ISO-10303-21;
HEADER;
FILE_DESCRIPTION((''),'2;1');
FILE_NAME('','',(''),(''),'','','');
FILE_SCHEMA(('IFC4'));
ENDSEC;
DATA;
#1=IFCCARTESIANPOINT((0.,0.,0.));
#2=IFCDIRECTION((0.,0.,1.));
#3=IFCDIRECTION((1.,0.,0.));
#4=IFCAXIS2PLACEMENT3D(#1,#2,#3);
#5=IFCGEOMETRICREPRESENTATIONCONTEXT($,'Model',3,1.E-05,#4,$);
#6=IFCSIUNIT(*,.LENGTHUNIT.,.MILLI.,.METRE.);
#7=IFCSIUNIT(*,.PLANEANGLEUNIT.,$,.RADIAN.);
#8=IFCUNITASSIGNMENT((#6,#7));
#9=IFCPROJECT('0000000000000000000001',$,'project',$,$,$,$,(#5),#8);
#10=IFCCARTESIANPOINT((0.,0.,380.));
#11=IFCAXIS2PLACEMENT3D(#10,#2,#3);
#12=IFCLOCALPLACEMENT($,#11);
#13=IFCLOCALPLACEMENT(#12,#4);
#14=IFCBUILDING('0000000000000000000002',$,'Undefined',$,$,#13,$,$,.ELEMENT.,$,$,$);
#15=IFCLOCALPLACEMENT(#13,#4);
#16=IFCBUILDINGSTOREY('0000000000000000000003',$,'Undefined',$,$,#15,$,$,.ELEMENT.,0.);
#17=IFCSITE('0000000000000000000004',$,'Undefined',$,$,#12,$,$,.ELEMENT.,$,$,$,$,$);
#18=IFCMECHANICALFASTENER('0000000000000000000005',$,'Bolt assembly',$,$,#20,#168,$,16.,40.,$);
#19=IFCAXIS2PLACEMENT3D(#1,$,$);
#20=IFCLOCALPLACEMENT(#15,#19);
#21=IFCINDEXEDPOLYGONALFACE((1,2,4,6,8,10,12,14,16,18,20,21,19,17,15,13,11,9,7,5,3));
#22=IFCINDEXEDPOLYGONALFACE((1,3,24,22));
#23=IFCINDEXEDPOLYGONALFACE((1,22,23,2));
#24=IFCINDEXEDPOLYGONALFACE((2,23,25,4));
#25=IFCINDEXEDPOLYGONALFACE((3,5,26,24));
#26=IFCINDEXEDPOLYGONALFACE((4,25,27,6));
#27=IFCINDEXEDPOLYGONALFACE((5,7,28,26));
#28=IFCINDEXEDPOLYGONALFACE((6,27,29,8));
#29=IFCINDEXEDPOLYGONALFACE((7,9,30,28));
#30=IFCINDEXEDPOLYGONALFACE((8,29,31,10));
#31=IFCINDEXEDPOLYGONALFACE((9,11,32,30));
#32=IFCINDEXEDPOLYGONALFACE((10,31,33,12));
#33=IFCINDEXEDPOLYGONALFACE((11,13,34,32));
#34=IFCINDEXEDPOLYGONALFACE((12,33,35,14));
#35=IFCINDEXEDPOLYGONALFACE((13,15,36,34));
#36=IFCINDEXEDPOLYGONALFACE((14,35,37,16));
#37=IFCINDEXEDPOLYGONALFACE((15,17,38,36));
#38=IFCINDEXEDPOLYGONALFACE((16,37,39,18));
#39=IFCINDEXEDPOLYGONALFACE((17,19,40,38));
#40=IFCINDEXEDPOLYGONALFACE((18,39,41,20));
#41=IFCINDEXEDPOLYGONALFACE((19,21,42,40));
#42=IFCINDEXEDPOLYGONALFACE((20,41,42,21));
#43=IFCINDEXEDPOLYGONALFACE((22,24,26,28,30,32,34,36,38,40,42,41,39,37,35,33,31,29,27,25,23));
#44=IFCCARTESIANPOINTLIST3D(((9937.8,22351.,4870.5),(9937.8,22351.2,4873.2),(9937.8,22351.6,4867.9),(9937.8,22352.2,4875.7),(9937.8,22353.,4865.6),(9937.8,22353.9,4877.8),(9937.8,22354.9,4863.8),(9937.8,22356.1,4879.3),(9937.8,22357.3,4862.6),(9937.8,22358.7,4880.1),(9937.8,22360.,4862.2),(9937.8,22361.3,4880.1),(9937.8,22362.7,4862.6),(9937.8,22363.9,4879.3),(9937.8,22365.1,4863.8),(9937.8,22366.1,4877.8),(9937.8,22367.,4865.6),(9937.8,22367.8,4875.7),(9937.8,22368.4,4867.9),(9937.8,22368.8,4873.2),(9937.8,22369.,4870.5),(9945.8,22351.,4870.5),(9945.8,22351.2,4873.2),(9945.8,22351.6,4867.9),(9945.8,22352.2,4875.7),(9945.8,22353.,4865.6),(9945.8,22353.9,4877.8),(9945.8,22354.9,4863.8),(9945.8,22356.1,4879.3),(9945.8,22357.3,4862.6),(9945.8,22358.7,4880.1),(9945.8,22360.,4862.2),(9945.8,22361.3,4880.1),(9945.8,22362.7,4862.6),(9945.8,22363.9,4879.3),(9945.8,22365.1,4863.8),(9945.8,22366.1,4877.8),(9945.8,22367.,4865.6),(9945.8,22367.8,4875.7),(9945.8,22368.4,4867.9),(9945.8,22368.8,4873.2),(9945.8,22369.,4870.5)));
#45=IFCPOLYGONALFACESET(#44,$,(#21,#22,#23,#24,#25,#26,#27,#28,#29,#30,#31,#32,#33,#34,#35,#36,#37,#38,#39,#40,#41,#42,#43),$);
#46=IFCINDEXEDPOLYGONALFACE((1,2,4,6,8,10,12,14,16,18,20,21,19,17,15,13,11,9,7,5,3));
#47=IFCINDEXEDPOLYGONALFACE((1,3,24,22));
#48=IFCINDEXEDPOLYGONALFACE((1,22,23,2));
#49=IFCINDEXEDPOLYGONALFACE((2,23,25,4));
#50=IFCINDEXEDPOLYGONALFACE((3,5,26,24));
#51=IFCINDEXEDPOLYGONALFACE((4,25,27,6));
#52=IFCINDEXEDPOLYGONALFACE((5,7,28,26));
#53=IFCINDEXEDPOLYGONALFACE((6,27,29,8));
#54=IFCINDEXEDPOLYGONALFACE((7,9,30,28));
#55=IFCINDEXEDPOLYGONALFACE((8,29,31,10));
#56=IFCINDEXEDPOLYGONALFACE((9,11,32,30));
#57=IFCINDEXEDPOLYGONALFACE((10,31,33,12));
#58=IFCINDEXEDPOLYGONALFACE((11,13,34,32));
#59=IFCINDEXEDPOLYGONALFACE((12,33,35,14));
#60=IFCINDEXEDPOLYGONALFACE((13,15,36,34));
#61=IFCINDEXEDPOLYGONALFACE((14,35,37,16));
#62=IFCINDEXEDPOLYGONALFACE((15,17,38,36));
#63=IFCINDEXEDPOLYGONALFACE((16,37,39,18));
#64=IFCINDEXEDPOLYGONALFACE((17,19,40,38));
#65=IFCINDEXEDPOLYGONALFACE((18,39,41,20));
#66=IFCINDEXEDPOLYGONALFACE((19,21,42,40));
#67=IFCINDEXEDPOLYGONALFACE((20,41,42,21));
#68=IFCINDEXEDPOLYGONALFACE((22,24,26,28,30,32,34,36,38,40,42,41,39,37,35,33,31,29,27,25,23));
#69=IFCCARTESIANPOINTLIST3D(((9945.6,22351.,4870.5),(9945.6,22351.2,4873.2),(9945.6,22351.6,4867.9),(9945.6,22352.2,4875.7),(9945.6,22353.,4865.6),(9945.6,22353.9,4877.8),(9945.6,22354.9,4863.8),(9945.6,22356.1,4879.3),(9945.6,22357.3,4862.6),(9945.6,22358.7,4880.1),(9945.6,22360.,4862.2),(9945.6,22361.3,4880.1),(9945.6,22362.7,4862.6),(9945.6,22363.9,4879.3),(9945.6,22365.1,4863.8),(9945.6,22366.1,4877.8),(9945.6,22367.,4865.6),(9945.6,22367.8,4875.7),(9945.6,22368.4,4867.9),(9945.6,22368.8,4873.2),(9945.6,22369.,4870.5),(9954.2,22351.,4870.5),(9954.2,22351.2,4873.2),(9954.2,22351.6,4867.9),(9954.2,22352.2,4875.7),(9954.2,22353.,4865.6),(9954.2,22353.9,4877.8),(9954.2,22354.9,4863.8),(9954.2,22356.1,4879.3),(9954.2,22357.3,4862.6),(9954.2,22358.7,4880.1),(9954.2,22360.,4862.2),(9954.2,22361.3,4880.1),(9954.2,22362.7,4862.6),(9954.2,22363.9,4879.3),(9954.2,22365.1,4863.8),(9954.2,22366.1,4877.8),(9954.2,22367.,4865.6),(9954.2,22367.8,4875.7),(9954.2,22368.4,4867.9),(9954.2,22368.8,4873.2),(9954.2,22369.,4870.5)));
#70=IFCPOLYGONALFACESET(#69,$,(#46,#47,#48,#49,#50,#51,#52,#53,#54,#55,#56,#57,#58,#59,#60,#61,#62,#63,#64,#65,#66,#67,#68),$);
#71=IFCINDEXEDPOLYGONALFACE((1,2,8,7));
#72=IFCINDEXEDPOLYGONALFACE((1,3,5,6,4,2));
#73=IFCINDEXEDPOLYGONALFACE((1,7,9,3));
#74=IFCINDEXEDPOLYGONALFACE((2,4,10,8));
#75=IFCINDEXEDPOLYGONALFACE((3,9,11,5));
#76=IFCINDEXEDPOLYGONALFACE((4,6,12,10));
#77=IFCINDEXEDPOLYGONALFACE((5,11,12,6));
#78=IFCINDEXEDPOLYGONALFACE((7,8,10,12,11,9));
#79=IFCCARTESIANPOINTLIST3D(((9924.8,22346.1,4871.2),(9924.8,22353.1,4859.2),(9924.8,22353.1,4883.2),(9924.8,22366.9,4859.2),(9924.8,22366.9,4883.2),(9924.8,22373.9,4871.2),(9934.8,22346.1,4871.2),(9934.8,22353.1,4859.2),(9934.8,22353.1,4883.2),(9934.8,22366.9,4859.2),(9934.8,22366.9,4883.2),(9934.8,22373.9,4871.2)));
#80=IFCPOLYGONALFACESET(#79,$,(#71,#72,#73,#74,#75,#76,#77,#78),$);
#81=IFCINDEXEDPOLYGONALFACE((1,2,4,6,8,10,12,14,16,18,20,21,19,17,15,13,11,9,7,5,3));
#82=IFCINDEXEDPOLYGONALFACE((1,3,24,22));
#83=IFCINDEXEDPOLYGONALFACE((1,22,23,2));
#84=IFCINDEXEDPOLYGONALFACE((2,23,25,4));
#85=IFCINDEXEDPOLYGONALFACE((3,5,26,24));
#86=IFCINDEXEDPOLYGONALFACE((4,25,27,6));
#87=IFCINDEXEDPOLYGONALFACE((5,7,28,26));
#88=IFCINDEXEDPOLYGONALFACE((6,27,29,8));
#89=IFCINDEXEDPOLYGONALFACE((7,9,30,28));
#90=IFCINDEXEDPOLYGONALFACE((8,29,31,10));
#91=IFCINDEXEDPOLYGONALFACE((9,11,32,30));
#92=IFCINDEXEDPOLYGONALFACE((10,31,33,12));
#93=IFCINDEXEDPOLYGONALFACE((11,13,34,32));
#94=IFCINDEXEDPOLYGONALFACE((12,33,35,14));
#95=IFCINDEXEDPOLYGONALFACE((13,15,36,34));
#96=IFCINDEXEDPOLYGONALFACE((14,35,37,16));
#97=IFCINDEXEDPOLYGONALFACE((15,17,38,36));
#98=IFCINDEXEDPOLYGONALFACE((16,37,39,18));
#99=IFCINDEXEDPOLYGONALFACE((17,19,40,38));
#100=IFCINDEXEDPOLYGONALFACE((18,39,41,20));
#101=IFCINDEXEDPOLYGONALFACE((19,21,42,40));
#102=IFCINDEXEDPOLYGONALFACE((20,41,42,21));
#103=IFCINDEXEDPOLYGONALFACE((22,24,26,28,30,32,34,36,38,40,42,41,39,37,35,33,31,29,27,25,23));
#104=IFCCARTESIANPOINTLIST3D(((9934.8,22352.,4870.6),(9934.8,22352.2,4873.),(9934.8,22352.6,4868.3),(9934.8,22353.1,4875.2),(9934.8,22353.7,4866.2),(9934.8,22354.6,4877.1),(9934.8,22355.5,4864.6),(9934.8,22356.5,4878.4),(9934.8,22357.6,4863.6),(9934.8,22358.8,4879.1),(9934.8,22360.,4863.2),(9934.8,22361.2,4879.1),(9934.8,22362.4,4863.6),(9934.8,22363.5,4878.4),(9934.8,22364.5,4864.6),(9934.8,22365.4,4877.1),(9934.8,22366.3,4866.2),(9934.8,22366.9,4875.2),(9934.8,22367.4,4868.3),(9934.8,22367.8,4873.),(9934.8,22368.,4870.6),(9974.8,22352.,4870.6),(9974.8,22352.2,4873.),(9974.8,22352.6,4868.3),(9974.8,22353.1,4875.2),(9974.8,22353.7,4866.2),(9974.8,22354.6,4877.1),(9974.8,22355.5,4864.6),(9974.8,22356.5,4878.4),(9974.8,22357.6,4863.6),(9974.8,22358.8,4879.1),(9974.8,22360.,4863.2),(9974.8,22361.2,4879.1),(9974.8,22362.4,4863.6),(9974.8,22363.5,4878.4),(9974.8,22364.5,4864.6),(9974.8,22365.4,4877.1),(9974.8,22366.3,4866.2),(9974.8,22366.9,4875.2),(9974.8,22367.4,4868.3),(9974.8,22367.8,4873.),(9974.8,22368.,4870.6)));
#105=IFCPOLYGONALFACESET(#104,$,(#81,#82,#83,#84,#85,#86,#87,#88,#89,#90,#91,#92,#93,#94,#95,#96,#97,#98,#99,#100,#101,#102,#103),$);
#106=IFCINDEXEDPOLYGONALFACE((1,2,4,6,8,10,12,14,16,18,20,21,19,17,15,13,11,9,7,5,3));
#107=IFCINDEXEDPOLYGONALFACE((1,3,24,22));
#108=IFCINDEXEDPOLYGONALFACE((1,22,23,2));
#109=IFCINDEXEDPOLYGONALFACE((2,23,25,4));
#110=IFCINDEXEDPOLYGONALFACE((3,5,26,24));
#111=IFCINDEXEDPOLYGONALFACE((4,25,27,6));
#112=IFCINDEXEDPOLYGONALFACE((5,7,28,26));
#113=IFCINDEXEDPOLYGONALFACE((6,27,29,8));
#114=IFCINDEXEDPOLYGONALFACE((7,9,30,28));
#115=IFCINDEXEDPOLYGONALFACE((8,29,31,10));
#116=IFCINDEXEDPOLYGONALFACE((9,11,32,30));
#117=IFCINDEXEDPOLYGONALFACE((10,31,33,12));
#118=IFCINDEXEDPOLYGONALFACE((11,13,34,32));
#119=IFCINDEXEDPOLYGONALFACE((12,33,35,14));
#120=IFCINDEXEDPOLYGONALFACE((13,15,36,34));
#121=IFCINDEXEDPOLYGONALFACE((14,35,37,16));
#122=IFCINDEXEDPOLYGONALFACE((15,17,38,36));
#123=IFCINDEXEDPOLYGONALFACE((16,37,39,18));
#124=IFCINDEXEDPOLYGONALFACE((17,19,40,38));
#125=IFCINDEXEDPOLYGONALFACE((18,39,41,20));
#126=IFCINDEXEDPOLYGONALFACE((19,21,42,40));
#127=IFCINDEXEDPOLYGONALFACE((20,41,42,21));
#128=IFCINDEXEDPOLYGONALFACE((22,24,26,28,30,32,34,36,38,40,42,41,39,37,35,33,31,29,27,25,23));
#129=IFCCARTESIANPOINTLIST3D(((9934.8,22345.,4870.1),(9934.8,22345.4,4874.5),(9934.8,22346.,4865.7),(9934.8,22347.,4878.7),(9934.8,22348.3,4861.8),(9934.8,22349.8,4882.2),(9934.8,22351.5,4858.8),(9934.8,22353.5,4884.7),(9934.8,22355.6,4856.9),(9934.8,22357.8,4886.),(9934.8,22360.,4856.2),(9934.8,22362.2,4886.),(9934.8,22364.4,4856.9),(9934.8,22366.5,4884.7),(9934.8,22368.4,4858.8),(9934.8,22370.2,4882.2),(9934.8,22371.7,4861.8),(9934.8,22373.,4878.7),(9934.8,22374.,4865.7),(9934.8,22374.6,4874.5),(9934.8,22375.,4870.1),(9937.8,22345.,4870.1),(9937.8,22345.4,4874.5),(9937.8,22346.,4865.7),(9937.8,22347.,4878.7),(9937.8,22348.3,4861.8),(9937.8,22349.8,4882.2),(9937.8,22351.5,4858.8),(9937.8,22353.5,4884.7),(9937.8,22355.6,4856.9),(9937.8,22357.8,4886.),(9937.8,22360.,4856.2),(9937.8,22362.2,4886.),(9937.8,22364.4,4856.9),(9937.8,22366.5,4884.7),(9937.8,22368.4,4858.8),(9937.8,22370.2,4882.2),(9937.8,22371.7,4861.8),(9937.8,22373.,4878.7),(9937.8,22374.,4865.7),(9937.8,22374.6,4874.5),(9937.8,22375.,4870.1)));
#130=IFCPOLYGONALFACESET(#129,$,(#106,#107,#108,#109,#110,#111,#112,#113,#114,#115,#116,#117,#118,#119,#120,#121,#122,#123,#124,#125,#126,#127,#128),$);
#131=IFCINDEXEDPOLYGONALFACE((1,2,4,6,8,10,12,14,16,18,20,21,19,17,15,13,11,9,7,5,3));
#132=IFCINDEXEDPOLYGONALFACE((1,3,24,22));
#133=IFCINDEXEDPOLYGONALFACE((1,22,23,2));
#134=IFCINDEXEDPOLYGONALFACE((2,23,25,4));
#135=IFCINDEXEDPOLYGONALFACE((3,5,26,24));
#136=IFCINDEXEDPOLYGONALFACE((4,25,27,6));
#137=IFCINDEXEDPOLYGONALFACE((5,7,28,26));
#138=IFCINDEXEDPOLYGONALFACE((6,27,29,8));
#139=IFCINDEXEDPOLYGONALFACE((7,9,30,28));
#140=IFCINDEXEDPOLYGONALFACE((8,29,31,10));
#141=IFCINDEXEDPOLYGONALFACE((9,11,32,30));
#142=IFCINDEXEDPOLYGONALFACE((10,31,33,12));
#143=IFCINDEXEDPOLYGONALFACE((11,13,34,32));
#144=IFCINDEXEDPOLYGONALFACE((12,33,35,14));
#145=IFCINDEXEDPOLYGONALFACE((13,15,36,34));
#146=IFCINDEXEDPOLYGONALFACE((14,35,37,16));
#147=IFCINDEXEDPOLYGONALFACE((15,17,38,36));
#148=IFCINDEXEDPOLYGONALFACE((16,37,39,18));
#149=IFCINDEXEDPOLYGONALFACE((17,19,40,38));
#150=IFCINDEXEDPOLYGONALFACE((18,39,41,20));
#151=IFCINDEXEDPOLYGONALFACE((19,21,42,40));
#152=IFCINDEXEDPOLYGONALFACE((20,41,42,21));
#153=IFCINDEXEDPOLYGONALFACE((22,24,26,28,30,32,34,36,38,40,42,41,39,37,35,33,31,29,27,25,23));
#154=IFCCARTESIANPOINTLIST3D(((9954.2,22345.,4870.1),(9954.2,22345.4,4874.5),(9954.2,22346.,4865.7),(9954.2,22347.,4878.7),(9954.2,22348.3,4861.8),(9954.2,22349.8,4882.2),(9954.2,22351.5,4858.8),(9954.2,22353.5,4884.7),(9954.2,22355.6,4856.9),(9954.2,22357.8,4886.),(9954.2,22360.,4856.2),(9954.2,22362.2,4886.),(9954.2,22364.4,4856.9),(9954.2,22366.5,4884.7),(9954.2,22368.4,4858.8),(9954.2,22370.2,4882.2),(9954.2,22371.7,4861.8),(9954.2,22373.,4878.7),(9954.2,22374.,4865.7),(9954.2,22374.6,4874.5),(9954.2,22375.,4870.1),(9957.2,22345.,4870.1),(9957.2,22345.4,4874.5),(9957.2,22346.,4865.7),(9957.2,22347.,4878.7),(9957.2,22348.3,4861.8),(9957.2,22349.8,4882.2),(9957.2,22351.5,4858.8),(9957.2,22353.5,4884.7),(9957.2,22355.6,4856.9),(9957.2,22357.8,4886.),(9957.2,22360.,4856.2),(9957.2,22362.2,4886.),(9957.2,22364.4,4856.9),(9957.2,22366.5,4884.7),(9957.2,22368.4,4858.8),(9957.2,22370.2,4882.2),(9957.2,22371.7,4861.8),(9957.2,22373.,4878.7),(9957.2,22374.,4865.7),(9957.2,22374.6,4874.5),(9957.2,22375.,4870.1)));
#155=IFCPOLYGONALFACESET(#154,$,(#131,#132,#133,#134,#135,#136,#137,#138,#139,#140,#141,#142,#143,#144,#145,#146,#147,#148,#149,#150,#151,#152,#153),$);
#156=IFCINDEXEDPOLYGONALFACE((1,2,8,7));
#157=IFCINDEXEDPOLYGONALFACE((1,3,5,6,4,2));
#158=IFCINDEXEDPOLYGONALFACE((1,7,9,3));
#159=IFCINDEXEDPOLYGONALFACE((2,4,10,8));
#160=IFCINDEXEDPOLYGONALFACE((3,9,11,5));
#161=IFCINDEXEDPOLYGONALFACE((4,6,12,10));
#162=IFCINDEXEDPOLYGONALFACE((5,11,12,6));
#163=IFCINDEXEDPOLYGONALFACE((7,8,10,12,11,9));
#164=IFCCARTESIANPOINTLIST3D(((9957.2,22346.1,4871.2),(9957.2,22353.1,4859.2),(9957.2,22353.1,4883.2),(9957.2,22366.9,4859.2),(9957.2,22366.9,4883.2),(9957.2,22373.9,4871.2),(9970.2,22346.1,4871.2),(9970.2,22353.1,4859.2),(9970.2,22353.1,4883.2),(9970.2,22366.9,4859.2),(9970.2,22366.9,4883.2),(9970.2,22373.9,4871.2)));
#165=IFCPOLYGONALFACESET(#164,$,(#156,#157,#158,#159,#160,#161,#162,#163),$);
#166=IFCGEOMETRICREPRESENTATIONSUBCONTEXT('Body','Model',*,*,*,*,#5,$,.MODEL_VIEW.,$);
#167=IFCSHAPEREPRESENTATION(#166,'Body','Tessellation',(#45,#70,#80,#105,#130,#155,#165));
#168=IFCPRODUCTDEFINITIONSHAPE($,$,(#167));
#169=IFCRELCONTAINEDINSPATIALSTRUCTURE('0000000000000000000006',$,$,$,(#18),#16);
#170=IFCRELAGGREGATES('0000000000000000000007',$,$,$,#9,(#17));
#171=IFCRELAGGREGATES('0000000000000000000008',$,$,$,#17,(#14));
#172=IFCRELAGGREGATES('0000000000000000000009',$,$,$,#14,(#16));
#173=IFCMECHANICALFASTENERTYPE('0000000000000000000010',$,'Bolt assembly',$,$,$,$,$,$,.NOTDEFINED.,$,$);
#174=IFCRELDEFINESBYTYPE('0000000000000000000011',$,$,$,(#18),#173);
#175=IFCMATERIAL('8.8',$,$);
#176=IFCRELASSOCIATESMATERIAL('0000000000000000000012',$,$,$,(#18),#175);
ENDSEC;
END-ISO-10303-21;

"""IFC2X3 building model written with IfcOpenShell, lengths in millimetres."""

from ifc_helpers import new_model, si_unit, frame, origin_with_axes, origin_2d_with_axis, place, context, subcontext, project, spatial, polyline, circle, outline, extrude, source, transform, mapped, material, type_object, element, save


model = new_model("IFC2X3")

# Units and contexts
model_context = context("Model", 3, precision=1e-05, world=origin_with_axes())
body_context = subcontext(model_context, "Body", "Model", "MODEL_VIEW")
ifc_project = project(units=[si_unit("LENGTHUNIT", "METRE", prefix="MILLI"), si_unit("PLANEANGLEUNIT", "RADIAN")], contexts=[model_context])

# Site, building, storey
site_placement = place(None, frame((0.0, 0.0, 380.0), z_axis=(0.0, 0.0, 1.0), x_axis=(1.0, 0.0, 0.0)))
site = spatial("IfcSite", under=ifc_project, at=site_placement, Name="Undefined", CompositionType="ELEMENT")
building_placement = place(site_placement, origin_with_axes())
building = spatial("IfcBuilding", under=site, at=building_placement, Name="Undefined", CompositionType="ELEMENT")
storey_placement = place(building_placement, origin_with_axes())
storey = spatial("IfcBuildingStorey", under=building, at=storey_placement, Name="Undefined", CompositionType="ELEMENT", Elevation=0.0)

# Mechanical fastener
ifc_material_1 = material(Name="8.8")
mechanical_fastener_type = type_object("IfcMechanicalFastenerType", Name="Bolt assembly")
shared_shape_1 = source(origin_with_axes(), body_context, "Body", "SweptSolid", [
    extrude(circle(Radius=9.0, at=origin_2d_with_axis()), frame((0.0, -7.9, 0.0), z_axis=(0.0, 1.0, 0.0), x_axis=(1.0, 0.0, 0.0)), (0.0, 0.0, 1.0), 8.0),
    extrude(circle(Radius=9.0, at=origin_2d_with_axis()), frame((0.0, -0.1, 0.0), z_axis=(0.0, 1.0, 0.0), x_axis=(1.0, 0.0, 0.0)), (0.0, 0.0, 1.0), 8.6),
    extrude(outline(polyline([(12.0, -6.9), (12.0, 6.9), (0.0, 13.9), (-12.0, 6.9), (-12.0, -6.9), (0.0, -13.9), (12.0, -6.9)])), frame((0.0, -21.0, 0.0), z_axis=(0.0, 1.0, 0.0), x_axis=(1.0, 0.0, 0.0)), (0.0, 0.0, 1.0), 10.0),
    extrude(circle(Radius=8.0, at=origin_2d_with_axis()), frame((0.0, -11.0, 0.0), z_axis=(0.0, 1.0, 0.0), x_axis=(1.0, 0.0, 0.0)), (0.0, 0.0, 1.0), 40.0),
    extrude(circle(Radius=15.0, at=origin_2d_with_axis()), frame((0.0, -11.0, 0.0), z_axis=(0.0, 1.0, 0.0), x_axis=(1.0, 0.0, 0.0)), (0.0, 0.0, 1.0), 3.0),
    extrude(circle(Radius=15.0, at=origin_2d_with_axis()), frame((0.0, 8.5, 0.0), z_axis=(0.0, 1.0, 0.0), x_axis=(1.0, 0.0, 0.0)), (0.0, 0.0, 1.0), 3.0),
    extrude(outline(polyline([(12.0, -6.9), (12.0, 6.9), (0.0, 13.9), (-12.0, 6.9), (-12.0, -6.9), (0.0, -13.9), (12.0, -6.9)])), frame((0.0, 11.5, 0.0), z_axis=(0.0, 1.0, 0.0), x_axis=(1.0, 0.0, 0.0)), (0.0, 0.0, 1.0), 13.0),
])
for number, where, z_axis, x_axis, name in (
    (1, (9945.8, 22397.5, 4951.2), (0.0, -1.0, 0.0), (0.0, 0.0, -1.0), "Bolt assembly"),
):
    element("IfcMechanicalFastener", number, at=place(storey_placement, frame(where, z_axis=z_axis, x_axis=x_axis)), inside=storey, type_object=mechanical_fastener_type, material=ifc_material_1, Name=name, NominalDiameter=16.0, NominalLength=40.0, context=body_context, shape_type="MappedRepresentation", body=[
        mapped(shared_shape_1, transform((80.0, 0.0, 37.5))),
    ])

save(model, "model.ifc")
